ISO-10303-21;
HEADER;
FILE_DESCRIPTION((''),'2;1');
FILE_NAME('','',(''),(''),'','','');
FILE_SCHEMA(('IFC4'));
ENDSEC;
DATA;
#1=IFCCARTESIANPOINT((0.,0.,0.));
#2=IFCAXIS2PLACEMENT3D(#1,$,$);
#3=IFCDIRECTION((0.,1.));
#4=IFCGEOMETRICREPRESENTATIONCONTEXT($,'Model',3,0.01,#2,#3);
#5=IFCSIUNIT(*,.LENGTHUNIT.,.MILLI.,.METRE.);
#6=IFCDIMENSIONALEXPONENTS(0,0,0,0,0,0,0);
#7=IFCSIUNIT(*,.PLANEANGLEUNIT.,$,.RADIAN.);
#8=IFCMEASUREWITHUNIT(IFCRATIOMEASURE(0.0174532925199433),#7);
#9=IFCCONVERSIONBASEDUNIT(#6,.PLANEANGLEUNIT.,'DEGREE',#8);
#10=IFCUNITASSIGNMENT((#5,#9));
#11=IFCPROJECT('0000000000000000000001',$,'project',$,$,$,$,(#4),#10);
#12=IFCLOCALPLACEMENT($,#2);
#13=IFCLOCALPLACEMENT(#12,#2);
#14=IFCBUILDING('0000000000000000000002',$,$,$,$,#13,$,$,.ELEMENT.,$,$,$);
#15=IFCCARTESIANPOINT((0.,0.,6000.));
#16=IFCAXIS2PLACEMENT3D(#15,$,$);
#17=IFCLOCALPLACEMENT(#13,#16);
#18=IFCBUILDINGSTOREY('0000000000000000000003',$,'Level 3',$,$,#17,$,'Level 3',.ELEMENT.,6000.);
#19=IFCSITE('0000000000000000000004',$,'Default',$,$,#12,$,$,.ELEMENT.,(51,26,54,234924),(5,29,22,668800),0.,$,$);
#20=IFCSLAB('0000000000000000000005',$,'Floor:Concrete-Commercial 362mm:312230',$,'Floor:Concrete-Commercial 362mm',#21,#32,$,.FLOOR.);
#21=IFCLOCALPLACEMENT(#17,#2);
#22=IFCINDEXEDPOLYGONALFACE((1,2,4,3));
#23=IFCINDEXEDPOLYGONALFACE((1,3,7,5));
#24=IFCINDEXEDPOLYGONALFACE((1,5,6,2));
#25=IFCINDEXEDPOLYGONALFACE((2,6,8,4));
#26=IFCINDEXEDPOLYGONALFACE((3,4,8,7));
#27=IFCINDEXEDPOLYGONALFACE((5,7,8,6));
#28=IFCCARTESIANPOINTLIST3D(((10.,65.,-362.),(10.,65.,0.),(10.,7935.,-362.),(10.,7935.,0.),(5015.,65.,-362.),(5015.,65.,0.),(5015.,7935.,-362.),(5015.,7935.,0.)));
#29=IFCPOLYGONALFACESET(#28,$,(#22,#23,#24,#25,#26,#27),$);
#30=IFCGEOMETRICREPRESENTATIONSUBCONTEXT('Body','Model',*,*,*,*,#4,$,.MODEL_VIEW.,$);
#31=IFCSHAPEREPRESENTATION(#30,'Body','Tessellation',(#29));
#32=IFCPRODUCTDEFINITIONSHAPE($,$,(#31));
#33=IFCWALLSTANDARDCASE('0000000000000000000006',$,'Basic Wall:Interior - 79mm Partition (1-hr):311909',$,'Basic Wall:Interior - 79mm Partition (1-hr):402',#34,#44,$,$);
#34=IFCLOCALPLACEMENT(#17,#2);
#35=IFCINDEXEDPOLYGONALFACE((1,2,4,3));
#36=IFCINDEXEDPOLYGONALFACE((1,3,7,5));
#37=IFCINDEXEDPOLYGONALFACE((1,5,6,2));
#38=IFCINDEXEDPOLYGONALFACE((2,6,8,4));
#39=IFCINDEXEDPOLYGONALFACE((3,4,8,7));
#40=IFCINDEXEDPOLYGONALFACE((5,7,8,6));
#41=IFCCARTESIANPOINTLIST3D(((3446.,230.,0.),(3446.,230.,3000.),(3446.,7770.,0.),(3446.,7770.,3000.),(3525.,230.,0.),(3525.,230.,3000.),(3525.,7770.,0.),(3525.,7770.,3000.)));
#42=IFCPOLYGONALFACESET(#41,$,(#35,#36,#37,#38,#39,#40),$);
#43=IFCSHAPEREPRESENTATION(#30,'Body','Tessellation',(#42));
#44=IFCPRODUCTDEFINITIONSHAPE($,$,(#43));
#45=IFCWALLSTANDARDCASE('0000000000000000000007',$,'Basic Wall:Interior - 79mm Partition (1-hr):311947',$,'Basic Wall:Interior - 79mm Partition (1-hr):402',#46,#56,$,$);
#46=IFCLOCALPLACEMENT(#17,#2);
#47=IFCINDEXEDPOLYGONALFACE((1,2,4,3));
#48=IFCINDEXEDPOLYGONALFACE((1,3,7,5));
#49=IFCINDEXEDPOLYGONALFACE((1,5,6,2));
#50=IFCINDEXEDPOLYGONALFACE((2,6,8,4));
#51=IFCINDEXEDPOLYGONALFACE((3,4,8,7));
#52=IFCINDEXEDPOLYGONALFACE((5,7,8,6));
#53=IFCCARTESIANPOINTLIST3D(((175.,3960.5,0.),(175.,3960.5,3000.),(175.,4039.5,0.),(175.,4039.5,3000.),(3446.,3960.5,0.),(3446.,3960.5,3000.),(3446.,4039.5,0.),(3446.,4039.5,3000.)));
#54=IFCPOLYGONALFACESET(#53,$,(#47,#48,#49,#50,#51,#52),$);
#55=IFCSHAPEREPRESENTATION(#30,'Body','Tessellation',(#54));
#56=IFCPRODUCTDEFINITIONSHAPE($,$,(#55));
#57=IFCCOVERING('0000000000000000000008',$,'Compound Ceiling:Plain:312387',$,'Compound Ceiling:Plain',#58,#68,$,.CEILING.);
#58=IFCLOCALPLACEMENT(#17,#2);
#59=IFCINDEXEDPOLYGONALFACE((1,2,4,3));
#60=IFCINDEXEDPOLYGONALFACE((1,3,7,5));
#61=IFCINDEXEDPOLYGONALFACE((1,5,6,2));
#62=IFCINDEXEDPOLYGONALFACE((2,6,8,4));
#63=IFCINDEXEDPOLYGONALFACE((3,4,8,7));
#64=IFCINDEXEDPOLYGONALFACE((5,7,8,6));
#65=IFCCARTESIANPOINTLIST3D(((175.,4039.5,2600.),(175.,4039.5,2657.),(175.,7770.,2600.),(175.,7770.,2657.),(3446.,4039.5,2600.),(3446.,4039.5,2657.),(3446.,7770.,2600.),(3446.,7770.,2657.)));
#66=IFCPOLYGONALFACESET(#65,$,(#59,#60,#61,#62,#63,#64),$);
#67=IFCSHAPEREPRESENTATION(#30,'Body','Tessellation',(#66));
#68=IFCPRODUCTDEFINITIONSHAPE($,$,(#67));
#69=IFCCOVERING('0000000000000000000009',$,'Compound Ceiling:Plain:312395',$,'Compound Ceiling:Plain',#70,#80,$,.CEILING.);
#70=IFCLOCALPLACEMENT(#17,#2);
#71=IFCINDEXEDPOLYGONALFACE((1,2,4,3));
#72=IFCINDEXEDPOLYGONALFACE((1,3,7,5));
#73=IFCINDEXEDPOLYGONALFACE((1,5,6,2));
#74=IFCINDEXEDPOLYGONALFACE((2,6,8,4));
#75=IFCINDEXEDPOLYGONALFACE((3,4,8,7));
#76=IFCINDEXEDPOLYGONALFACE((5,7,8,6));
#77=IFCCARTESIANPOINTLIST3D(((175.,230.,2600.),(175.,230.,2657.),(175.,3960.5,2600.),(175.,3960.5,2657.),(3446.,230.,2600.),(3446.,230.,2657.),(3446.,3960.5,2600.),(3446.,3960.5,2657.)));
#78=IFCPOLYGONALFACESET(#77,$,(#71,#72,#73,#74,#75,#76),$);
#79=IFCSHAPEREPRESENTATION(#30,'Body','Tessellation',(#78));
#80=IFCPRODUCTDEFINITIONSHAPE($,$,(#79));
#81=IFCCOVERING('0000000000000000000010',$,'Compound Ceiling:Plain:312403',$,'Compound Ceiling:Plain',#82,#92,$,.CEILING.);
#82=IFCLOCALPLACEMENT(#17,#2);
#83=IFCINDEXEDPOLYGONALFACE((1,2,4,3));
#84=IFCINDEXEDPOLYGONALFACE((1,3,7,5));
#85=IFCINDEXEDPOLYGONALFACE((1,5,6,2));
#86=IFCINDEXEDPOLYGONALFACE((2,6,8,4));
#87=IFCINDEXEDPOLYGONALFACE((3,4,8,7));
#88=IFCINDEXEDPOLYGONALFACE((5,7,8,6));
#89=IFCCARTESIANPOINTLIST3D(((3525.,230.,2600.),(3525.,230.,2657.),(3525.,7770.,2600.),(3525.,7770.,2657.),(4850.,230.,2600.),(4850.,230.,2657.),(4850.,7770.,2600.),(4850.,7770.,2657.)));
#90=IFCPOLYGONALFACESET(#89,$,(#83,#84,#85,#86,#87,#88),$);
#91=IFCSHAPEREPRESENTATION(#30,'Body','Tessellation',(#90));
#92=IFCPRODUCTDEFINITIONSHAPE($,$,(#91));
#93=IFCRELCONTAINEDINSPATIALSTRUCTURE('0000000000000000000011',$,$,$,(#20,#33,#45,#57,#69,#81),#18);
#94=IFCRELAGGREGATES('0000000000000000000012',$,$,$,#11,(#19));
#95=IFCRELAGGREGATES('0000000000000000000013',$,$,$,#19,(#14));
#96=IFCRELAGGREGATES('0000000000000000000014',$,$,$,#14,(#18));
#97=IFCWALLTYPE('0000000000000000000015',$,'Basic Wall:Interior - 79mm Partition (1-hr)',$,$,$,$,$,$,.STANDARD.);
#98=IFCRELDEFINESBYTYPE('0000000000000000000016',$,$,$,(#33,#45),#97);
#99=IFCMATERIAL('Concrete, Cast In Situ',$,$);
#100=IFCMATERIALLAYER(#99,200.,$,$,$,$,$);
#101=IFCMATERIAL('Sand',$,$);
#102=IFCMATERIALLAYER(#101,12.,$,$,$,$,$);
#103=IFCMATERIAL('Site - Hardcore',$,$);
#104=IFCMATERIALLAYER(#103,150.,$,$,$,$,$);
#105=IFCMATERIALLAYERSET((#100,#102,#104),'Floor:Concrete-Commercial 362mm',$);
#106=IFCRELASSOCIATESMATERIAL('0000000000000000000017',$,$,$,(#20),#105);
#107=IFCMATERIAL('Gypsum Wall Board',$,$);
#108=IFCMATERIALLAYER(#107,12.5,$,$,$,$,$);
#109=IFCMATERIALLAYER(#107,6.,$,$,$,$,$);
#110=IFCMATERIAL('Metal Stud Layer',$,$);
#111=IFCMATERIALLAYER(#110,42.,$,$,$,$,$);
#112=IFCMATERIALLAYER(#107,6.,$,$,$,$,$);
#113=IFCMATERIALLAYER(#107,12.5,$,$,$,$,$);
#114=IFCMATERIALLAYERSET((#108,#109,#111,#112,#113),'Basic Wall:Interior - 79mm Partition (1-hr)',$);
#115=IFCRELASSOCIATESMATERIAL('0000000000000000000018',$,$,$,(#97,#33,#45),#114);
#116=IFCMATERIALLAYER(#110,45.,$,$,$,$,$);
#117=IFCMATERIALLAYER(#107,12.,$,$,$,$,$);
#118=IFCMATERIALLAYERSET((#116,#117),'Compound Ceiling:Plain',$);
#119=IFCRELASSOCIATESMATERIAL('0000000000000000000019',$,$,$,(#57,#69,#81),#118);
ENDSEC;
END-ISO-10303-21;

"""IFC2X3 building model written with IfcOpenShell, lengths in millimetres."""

from ifc_helpers import new_model, entity, si_unit, converted_unit, direction, frame, frame_2d, origin, origin_2d_with_axis, place, context, subcontext, project, spatial, rectangle, extrude, material, layer, layer_set, layer_usage, type_object, element, save


model = new_model("IFC2X3")

# Units and contexts
model_context = context("Model", 3, precision=0.01, world=origin(), true_north=direction((0.0, 1.0)))
body_context = subcontext(model_context, "Body", "Model", "MODEL_VIEW")
ifc_project = project(units=[si_unit("LENGTHUNIT", "METRE", prefix="MILLI"), converted_unit("PLANEANGLEUNIT", "DEGREE", entity("IfcRatioMeasure", 0.0174532925199433), si_unit("PLANEANGLEUNIT", "RADIAN"), dimensions=[0, 0, 0, 0, 0, 0, 0])], contexts=[model_context])

# Site, building, storey
site_placement = place(None, origin())
site = spatial("IfcSite", under=ifc_project, at=site_placement, Name="Default", CompositionType="ELEMENT", RefLatitude=(51, 26, 54, 234924), RefLongitude=(5, 29, 22, 668800), RefElevation=0.0)
building_placement = place(site_placement, origin())
building = spatial("IfcBuilding", under=site, at=building_placement, CompositionType="ELEMENT")
storey_placement = place(building_placement, frame((0.0, 0.0, 6000.0)))
storey = spatial("IfcBuildingStorey", under=building, at=storey_placement, Name="Level 3", LongName="Level 3", CompositionType="ELEMENT", Elevation=6000.0)

# Slab
ifc_material_1 = material(Name="Concrete, Cast In Situ")
ifc_layer_1 = layer(ifc_material_1, 200.0)
ifc_material_2 = material(Name="Sand")
ifc_layer_2 = layer(ifc_material_2, 12.0)
ifc_material_3 = material(Name="Site - Hardcore")
ifc_layer_3 = layer(ifc_material_3, 150.0)
ifc_layer_set_1 = layer_set([ifc_layer_1, ifc_layer_2, ifc_layer_3], Name="Floor:Concrete-Commercial 362mm")
ifc_layer_usage_1 = layer_usage(ifc_layer_set_1, "AXIS3", "POSITIVE", 0.0)
slab_placement = place(storey_placement, origin())
element("IfcSlab", 1, at=slab_placement, inside=storey, material=ifc_layer_usage_1, Name="Floor:Concrete-Commercial 362mm:312230", ObjectType="Floor:Concrete-Commercial 362mm", PredefinedType="FLOOR", context=body_context, shape_type="SweptSolid", body=[
    extrude(rectangle(XDim=7870.0, YDim=5005.0, at=origin_2d_with_axis()), frame((2512.5, 4000.0, 0.0), z_axis=(0.0, 0.0, -1.0), x_axis=(0.0, 1.0, 0.0)), (0.0, 0.0, 1.0), 362.0),
])

# Walls
ifc_material_4 = material(Name="Gypsum Wall Board")
ifc_layer_4 = layer(ifc_material_4, 12.5)
ifc_layer_5 = layer(ifc_material_4, 6.0)
ifc_material_5 = material(Name="Metal Stud Layer")
ifc_layer_6 = layer(ifc_material_5, 42.0)
ifc_layer_7 = layer(ifc_material_4, 6.0)
ifc_layer_8 = layer(ifc_material_4, 12.5)
ifc_layer_set_2 = layer_set([ifc_layer_4, ifc_layer_5, ifc_layer_6, ifc_layer_7, ifc_layer_8], Name="Basic Wall:Interior - 79mm Partition (1-hr)")
ifc_layer_usage_2 = layer_usage(ifc_layer_set_2, "AXIS2", "NEGATIVE", 39.5)
wall_type = type_object("IfcWallType", Name="Basic Wall:Interior - 79mm Partition (1-hr)", PredefinedType="STANDARD", material=ifc_layer_set_2)
wall_1_placement = place(storey_placement, frame((3485.5, 7770.0, 0.0), z_axis=(0.0, 0.0, 1.0), x_axis=(0.0, -1.0, 0.0)))
element("IfcWallStandardCase", 2, at=wall_1_placement, inside=storey, type_object=wall_type, material=ifc_layer_usage_2, Name="Basic Wall:Interior - 79mm Partition (1-hr):311909", ObjectType="Basic Wall:Interior - 79mm Partition (1-hr):402", context=body_context, shape_type="SweptSolid", body=[
    extrude(rectangle(XDim=7540.0, YDim=79.0, at=frame_2d((3770.0, 0.0), x_axis=(-1.0, 0.0))), origin(), (0.0, 0.0, 1.0), 3000.0),
])
ifc_layer_usage_3 = layer_usage(ifc_layer_set_2, "AXIS2", "NEGATIVE", 39.5)
wall_2_placement = place(storey_placement, frame((3446.0, 4000.0, 0.0), z_axis=(0.0, 0.0, 1.0), x_axis=(-1.0, 0.0, 0.0)))
element("IfcWallStandardCase", 3, at=wall_2_placement, inside=storey, type_object=wall_type, material=ifc_layer_usage_3, Name="Basic Wall:Interior - 79mm Partition (1-hr):311947", ObjectType="Basic Wall:Interior - 79mm Partition (1-hr):402", context=body_context, shape_type="SweptSolid", body=[
    extrude(rectangle(XDim=3271.0, YDim=79.0, at=frame_2d((1635.5, 0.0), x_axis=(-1.0, 0.0))), origin(), (0.0, 0.0, 1.0), 3000.0),
])

# Coverings
ifc_layer_9 = layer(ifc_material_5, 45.0)
ifc_layer_10 = layer(ifc_material_4, 12.0)
ifc_layer_set_3 = layer_set([ifc_layer_9, ifc_layer_10], Name="Compound Ceiling:Plain")
ifc_layer_usage_4 = layer_usage(ifc_layer_set_3, "AXIS3", "NEGATIVE", 0.0)
covering_1_placement = place(storey_placement, origin())
element("IfcCovering", 4, at=covering_1_placement, inside=storey, material=ifc_layer_usage_4, Name="Compound Ceiling:Plain:312387", ObjectType="Compound Ceiling:Plain", PredefinedType="CEILING", context=body_context, shape_type="SweptSolid", body=[
    extrude(rectangle(XDim=3271.0, YDim=3730.5, at=frame_2d((0.0, 0.0), x_axis=(1.0, 0.0))), frame((1810.5, 5904.8, 2600.0)), (0.0, 0.0, 1.0), 57.0),
])
ifc_layer_usage_5 = layer_usage(ifc_layer_set_3, "AXIS3", "NEGATIVE", 0.0)
covering_2_placement = place(storey_placement, origin())
element("IfcCovering", 5, at=covering_2_placement, inside=storey, material=ifc_layer_usage_5, Name="Compound Ceiling:Plain:312395", ObjectType="Compound Ceiling:Plain", PredefinedType="CEILING", context=body_context, shape_type="SweptSolid", body=[
    extrude(rectangle(XDim=3271.0, YDim=3730.5, at=origin_2d_with_axis()), frame((1810.5, 2095.2, 2600.0)), (0.0, 0.0, 1.0), 57.0),
])
ifc_layer_usage_6 = layer_usage(ifc_layer_set_3, "AXIS3", "NEGATIVE", 0.0)
covering_3_placement = place(storey_placement, origin())
element("IfcCovering", 6, at=covering_3_placement, inside=storey, material=ifc_layer_usage_6, Name="Compound Ceiling:Plain:312403", ObjectType="Compound Ceiling:Plain", PredefinedType="CEILING", context=body_context, shape_type="SweptSolid", body=[
    extrude(rectangle(XDim=1325.0, YDim=7540.0, at=frame_2d((0.0, 0.0), x_axis=(1.0, 0.0))), frame((4187.5, 4000.0, 2600.0)), (0.0, 0.0, 1.0), 57.0),
])

save(model, "model.ifc")
